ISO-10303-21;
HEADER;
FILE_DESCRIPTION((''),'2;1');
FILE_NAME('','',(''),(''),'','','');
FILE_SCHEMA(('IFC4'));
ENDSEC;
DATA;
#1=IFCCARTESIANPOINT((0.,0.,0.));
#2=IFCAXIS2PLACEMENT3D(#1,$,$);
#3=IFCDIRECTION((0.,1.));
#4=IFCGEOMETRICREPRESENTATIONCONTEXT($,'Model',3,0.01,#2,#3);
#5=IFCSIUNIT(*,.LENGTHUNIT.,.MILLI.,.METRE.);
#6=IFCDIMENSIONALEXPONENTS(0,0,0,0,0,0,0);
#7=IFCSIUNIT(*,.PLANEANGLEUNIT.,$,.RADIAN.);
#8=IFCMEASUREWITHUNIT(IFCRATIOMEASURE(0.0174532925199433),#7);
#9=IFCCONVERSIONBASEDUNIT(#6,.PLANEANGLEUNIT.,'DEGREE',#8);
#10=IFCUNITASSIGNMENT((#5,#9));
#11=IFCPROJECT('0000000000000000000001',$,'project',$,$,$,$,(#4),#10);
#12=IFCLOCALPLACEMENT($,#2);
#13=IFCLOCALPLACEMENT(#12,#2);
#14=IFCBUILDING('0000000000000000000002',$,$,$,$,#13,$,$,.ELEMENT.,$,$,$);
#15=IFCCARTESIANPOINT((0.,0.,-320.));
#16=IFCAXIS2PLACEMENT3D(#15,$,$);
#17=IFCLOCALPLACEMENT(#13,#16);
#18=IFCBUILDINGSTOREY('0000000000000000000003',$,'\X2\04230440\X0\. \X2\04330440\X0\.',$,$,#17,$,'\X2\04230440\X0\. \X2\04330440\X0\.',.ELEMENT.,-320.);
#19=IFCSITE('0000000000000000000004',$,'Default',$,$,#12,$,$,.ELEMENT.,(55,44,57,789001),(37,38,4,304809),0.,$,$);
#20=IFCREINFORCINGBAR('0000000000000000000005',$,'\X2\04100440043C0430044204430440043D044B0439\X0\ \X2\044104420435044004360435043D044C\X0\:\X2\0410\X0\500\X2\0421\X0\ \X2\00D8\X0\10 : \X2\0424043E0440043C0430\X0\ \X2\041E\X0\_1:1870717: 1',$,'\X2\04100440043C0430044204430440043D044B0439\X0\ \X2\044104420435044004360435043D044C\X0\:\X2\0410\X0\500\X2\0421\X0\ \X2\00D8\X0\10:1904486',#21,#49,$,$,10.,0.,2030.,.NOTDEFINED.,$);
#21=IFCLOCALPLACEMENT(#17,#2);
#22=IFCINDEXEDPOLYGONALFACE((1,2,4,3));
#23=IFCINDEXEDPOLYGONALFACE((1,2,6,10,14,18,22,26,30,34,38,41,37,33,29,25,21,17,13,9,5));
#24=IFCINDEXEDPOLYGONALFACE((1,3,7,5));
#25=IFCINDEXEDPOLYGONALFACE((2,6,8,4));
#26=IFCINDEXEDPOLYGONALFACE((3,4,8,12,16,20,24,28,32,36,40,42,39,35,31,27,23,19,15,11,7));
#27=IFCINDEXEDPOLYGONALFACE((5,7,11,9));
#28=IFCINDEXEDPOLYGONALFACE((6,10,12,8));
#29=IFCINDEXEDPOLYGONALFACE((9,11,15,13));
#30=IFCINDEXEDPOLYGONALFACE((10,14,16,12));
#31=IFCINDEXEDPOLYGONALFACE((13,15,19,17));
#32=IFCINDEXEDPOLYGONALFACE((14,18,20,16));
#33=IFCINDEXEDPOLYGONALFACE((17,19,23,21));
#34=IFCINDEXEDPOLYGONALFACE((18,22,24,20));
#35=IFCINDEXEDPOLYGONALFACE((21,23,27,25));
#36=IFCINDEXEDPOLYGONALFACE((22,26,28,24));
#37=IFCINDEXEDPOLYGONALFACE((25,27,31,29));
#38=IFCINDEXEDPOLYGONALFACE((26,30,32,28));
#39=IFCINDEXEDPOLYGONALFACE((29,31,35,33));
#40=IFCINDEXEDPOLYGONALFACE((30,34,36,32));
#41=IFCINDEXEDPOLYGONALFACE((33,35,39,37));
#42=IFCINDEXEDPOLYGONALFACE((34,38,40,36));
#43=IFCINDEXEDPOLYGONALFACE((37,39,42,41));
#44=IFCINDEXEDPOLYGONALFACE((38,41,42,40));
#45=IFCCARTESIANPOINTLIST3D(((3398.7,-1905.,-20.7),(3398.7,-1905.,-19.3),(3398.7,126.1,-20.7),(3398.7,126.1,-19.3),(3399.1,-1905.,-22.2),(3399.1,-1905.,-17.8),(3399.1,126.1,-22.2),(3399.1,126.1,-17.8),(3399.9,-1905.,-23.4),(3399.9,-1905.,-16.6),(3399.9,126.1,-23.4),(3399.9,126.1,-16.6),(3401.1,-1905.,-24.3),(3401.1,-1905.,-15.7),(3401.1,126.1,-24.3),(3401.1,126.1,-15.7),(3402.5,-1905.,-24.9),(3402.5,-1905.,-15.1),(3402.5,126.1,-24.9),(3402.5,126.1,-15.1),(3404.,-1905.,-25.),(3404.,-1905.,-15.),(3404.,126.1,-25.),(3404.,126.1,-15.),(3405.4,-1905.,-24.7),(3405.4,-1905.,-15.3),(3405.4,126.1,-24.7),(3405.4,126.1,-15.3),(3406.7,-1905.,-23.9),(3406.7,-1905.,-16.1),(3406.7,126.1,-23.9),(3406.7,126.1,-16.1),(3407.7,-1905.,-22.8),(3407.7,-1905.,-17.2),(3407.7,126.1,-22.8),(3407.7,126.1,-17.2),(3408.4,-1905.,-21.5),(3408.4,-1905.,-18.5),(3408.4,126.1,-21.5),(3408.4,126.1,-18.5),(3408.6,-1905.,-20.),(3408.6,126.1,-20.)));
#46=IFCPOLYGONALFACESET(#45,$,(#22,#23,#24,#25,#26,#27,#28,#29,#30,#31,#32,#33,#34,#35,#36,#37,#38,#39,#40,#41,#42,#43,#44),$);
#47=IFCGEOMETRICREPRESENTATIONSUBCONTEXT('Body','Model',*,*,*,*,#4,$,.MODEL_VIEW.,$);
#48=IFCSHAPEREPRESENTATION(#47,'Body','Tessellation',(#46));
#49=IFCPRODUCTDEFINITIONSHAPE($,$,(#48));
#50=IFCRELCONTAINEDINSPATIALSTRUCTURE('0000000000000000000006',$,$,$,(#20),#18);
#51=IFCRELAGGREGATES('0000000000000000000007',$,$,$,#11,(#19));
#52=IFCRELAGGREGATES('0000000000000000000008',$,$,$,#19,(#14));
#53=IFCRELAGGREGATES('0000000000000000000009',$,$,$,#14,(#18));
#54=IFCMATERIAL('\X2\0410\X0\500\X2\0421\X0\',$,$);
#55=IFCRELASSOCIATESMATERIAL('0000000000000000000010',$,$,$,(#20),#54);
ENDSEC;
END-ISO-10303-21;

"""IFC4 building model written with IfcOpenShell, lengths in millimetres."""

from ifc_helpers import new_model, entity, si_unit, converted_unit, direction, frame, origin, place, context, subcontext, project, spatial, material, element, save


model = new_model("IFC4")

# Units and contexts
model_context = context("Model", 3, precision=0.01, world=origin(), true_north=direction((0.0, 1.0)))
body_context = subcontext(model_context, "Body", "Model", "MODEL_VIEW")
ifc_project = project(units=[si_unit("LENGTHUNIT", "METRE", prefix="MILLI"), converted_unit("PLANEANGLEUNIT", "DEGREE", entity("IfcRatioMeasure", 0.0174532925199433), si_unit("PLANEANGLEUNIT", "RADIAN"), dimensions=[0, 0, 0, 0, 0, 0, 0])], contexts=[model_context])

# Site, building, storey
site_placement = place(None, origin())
site = spatial("IfcSite", under=ifc_project, at=site_placement, Name="Default", CompositionType="ELEMENT", RefLatitude=(55, 44, 57, 789001), RefLongitude=(37, 38, 4, 304809), RefElevation=0.0)
building_placement = place(site_placement, origin())
building = spatial("IfcBuilding", under=site, at=building_placement, CompositionType="ELEMENT")
storey_placement = place(building_placement, frame((0.0, 0.0, -320.0)))
storey = spatial("IfcBuildingStorey", under=building, at=storey_placement, Name="Ур. гр.", LongName="Ур. гр.", CompositionType="ELEMENT", Elevation=-320.0)

# Reinforcing bar
ifc_material_1 = material(Name="А500С")
reinforcing_bar_1_placement = place(storey_placement, origin())
element("IfcReinforcingBar", 1, at=reinforcing_bar_1_placement, inside=storey, material=ifc_material_1, Name="Арматурный стержень:А500С Ø10 : Форма О_1:1870717: 1", ObjectType="Арматурный стержень:А500С Ø10:1904486", BarLength=2030.0, CrossSectionArea=0.0, NominalDiameter=10.0, PredefinedType="NOTDEFINED", context=body_context, shape_type="AdvancedSweptSolid", body=[
    entity("IfcSweptDiskSolid", entity("IfcCompositeCurve", [entity("IfcCompositeCurveSegment", "CONTINUOUS", True, entity("IfcPolyline", [entity("IfcCartesianPoint", [3403.6, -1905.0, -20.0]), entity("IfcCartesianPoint", [3403.6, 126.1, -20.0])]))], False), 5.0, None, 0.0, 1.0),
])

save(model, "model.ifc")
